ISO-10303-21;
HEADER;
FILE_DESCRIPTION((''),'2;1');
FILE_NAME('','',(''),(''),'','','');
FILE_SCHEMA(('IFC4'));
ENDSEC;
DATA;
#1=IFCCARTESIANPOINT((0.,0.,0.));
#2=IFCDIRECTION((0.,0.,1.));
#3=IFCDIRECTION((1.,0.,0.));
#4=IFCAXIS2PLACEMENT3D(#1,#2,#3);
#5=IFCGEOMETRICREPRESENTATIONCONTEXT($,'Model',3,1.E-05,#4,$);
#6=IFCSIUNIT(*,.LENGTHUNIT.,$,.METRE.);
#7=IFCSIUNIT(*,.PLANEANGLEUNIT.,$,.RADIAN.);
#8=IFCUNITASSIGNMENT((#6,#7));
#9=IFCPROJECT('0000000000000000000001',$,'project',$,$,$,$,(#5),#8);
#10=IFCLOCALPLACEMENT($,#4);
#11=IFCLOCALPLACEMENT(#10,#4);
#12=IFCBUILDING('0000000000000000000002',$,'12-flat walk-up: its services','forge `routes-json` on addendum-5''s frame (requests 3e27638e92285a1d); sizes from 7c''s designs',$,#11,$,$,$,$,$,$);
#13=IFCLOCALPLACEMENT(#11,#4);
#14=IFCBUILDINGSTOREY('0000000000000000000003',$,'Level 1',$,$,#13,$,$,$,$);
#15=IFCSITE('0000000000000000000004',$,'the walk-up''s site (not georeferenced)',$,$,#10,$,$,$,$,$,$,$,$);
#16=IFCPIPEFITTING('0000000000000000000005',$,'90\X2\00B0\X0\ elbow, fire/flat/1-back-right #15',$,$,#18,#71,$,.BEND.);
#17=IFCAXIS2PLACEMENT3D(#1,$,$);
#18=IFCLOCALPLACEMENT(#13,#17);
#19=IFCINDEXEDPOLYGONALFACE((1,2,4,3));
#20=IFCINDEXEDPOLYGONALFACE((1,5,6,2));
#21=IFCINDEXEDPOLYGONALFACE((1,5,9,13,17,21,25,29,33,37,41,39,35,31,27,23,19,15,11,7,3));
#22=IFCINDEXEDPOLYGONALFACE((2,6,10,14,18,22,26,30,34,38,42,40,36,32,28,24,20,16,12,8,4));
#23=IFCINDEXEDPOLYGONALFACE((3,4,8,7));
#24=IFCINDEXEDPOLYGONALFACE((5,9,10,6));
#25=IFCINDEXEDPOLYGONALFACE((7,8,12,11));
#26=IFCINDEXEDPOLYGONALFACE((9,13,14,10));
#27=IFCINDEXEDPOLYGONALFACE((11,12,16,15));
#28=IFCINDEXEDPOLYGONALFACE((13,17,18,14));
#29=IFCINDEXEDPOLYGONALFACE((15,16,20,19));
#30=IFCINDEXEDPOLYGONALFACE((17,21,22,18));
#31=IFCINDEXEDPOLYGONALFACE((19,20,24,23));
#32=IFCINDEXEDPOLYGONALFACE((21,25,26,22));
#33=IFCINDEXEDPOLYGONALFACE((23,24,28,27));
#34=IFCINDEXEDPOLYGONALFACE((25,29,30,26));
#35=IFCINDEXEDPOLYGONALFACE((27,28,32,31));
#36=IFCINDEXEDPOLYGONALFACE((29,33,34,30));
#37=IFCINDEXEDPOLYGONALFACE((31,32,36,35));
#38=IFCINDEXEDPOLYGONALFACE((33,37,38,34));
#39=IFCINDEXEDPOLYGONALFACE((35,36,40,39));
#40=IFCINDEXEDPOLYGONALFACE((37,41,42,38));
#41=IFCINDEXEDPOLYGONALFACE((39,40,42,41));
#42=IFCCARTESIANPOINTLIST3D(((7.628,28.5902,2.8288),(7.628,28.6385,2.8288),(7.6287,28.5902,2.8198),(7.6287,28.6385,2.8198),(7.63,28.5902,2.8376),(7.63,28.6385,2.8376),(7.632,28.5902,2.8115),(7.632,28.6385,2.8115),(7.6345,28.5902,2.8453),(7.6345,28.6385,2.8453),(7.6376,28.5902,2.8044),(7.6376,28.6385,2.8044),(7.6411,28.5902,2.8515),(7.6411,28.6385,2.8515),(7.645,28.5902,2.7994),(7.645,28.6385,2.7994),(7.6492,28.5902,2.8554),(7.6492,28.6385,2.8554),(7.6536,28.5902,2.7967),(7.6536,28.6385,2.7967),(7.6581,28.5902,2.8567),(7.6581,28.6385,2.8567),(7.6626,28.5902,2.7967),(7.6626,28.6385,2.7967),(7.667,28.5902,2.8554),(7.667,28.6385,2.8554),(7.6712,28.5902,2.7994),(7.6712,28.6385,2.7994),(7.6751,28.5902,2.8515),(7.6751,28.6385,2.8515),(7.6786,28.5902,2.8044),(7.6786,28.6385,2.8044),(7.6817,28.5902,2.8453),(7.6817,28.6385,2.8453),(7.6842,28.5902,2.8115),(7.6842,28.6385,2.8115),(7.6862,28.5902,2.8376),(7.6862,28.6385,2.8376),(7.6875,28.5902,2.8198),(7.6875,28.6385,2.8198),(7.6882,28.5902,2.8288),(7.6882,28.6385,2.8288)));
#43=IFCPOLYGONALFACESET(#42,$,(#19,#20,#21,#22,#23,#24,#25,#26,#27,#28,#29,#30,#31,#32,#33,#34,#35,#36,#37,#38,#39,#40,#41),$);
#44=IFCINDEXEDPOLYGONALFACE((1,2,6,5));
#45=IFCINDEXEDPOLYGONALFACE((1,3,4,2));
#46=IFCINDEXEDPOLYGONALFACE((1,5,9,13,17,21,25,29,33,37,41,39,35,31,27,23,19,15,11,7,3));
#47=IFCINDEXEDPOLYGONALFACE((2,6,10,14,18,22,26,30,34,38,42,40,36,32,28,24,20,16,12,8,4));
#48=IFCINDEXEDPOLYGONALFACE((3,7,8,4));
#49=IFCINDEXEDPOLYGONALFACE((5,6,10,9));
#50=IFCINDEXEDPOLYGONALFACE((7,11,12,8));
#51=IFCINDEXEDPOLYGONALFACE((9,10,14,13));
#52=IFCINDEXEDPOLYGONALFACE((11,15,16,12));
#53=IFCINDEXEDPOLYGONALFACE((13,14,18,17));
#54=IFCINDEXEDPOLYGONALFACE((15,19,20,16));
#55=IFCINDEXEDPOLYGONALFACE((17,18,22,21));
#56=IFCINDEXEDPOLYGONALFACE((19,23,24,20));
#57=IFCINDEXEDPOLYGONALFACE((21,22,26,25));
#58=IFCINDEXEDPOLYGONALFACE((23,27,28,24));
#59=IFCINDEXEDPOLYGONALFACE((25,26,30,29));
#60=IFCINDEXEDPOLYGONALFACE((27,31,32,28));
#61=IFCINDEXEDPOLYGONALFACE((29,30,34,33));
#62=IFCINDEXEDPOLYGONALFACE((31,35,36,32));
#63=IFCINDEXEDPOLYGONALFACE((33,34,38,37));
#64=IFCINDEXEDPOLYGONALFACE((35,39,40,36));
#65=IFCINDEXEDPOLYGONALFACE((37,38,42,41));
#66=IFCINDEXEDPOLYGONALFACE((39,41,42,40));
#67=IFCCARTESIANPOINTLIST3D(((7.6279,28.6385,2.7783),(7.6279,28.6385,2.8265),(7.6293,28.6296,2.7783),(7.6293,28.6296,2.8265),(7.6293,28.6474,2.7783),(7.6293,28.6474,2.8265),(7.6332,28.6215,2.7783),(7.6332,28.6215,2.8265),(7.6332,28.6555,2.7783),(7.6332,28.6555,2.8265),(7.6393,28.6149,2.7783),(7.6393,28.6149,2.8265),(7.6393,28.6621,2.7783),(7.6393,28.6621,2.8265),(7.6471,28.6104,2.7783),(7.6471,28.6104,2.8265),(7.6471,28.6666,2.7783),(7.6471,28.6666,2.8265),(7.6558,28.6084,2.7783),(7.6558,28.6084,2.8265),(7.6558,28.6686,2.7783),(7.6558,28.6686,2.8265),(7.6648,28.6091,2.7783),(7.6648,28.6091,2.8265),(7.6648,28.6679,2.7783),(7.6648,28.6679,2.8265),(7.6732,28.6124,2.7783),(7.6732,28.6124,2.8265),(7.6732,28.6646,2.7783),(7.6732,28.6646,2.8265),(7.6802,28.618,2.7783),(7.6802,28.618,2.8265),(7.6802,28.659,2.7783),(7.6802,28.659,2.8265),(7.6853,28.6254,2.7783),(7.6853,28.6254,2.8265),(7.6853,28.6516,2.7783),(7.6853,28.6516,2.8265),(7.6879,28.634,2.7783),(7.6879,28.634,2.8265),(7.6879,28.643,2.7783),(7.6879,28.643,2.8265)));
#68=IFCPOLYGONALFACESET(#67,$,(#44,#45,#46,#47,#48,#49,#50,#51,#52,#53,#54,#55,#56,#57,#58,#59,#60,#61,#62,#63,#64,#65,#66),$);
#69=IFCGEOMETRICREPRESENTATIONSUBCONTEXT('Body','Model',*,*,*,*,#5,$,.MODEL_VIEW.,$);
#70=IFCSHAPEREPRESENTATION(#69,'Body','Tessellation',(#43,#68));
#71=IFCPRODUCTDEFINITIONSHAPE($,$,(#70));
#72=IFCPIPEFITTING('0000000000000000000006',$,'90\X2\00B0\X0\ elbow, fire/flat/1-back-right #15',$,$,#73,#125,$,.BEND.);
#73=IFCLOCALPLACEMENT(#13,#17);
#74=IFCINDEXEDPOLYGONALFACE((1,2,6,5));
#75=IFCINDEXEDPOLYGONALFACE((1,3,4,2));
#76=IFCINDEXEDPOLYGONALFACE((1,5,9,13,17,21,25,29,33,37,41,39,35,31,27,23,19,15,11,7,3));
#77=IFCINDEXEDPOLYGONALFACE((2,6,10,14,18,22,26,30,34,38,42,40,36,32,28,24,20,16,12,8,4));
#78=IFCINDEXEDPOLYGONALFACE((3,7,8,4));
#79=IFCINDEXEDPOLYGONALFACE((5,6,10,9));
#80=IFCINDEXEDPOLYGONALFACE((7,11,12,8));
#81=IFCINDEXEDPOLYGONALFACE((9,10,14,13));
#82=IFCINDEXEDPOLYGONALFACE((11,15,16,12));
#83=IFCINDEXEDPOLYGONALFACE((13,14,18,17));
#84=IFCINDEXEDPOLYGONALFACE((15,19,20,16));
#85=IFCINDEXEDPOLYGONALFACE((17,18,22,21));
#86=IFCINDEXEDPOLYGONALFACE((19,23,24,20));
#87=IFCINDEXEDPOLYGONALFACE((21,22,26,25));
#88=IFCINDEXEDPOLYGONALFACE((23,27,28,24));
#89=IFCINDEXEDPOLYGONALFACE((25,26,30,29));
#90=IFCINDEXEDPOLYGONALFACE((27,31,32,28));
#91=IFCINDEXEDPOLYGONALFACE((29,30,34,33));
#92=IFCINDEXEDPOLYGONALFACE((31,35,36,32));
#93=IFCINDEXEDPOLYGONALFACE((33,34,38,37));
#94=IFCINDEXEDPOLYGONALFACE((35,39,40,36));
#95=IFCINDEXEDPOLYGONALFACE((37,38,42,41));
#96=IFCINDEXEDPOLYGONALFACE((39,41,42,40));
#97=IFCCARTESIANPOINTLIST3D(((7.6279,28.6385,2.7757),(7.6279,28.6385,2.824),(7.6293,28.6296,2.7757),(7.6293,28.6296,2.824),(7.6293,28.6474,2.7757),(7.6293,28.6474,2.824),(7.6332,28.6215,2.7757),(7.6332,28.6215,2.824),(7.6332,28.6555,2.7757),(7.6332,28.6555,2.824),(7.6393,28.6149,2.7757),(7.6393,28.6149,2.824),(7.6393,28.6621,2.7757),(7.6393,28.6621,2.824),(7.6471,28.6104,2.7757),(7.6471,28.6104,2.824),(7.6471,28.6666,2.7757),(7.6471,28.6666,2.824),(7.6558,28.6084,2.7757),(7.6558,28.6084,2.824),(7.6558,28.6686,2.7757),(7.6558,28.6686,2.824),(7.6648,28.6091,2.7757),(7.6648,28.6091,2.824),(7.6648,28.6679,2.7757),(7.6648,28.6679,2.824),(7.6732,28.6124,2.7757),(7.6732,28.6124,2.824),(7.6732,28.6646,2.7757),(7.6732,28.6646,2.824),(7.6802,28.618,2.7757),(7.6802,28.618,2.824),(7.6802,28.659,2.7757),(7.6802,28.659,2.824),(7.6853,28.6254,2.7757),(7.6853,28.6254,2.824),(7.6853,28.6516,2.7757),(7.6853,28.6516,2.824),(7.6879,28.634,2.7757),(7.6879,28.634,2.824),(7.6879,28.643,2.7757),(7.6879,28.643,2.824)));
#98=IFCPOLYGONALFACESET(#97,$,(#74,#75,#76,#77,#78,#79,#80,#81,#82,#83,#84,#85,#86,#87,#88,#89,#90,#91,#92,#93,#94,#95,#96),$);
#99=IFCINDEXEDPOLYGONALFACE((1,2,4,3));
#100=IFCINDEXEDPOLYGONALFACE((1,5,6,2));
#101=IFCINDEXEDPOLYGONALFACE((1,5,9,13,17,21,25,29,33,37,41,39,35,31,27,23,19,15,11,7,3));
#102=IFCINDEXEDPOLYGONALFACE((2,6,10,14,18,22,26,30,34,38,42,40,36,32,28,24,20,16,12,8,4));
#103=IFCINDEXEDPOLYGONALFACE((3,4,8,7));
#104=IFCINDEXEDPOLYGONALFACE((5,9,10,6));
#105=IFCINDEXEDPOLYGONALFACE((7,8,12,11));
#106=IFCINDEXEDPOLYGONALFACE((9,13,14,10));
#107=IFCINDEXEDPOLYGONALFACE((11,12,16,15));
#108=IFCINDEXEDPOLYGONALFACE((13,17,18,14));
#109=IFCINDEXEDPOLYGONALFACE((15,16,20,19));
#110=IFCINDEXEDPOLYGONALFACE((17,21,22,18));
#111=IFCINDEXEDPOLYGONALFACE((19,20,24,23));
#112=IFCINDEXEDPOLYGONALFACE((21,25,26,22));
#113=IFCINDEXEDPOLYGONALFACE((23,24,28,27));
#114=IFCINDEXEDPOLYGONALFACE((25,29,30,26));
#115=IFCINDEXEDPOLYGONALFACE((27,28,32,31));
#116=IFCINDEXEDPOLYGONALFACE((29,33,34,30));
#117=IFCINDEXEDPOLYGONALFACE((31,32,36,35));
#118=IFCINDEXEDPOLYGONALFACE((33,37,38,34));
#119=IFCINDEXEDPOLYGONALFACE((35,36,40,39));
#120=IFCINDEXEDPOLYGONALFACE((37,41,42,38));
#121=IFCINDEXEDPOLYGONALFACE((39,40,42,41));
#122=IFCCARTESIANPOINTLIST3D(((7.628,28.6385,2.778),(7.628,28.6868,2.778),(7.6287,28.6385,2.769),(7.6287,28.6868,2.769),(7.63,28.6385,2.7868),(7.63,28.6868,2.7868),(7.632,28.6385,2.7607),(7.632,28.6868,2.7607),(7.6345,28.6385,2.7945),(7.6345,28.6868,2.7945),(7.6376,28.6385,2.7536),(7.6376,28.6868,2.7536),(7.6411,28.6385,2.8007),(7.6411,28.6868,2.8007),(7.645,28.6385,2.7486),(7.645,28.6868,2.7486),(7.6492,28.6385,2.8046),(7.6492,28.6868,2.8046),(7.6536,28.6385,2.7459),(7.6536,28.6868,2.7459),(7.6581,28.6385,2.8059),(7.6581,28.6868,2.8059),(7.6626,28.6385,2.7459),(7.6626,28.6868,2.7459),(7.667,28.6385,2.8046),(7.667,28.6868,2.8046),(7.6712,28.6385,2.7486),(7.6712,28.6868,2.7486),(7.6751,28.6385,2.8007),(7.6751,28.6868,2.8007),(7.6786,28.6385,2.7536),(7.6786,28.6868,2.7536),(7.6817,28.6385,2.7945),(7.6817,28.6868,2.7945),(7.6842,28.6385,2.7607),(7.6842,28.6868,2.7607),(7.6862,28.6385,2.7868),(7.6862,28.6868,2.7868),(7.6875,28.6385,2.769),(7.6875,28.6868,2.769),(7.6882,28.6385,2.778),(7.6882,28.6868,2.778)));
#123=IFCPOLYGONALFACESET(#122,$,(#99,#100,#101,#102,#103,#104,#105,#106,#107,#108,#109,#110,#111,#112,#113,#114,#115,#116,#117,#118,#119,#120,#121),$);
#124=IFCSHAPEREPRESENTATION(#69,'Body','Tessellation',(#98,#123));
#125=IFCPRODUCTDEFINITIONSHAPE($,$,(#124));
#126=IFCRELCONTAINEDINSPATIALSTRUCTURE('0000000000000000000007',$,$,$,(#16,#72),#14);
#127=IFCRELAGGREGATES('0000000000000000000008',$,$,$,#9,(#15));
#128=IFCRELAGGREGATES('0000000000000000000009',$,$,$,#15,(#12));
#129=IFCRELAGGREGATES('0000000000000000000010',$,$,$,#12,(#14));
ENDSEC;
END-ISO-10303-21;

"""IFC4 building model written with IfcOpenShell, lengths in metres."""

from ifc_helpers import new_model, entity, si_unit, frame, origin_with_axes, place, context, subcontext, project, spatial, element, save


model = new_model("IFC4")

# Units and contexts
model_context = context("Model", 3, precision=1e-05, world=origin_with_axes())
body_context = subcontext(model_context, "Body", "Model", "MODEL_VIEW")
ifc_project = project(units=[si_unit("LENGTHUNIT", "METRE"), si_unit("PLANEANGLEUNIT", "RADIAN")], contexts=[model_context])

# Site, building, storey
site_placement = place(None, origin_with_axes())
site = spatial("IfcSite", under=ifc_project, at=site_placement, Name="the walk-up's site (not georeferenced)")
building_placement = place(site_placement, origin_with_axes())
building = spatial("IfcBuilding", under=site, at=building_placement, Name="12-flat walk-up: its services", Description="forge `routes-json` on addendum-5's frame (requests 3e27638e92285a1d); sizes from 7c's designs")
storey_placement = place(building_placement, origin_with_axes())
storey = spatial("IfcBuildingStorey", under=building, at=storey_placement, Name="Level 1")

# Pipe fittings
pipe_fitting_1_placement = place(storey_placement, frame((7.6581, 28.5902, 2.8265), z_axis=(0.0, 0.0, 1.0), x_axis=(1.0, 0.0, 0.0)))
element("IfcPipeFitting", 1, at=pipe_fitting_1_placement, inside=storey, Name="90° elbow, fire/flat/1-back-right #15", PredefinedType="BEND", context=body_context, shape_type="AdvancedSweptSolid", body=[
    entity("IfcSweptDiskSolid", entity("IfcPolyline", [entity("IfcCartesianPoint", [0.0, 0.0, 0.0]), entity("IfcCartesianPoint", [0.0, 0.0483, 0.0])]), 0.0302),
    entity("IfcSweptDiskSolid", entity("IfcPolyline", [entity("IfcCartesianPoint", [0.0, 0.0483, 0.0]), entity("IfcCartesianPoint", [0.0, 0.0483, -0.0483])]), 0.0302),
])
pipe_fitting_2_placement = place(storey_placement, frame((7.6581, 28.6385, 2.824), z_axis=(0.0, 0.0, 1.0), x_axis=(1.0, 0.0, 0.0)))
element("IfcPipeFitting", 2, at=pipe_fitting_2_placement, inside=storey, Name="90° elbow, fire/flat/1-back-right #15", PredefinedType="BEND", context=body_context, shape_type="AdvancedSweptSolid", body=[
    entity("IfcSweptDiskSolid", entity("IfcPolyline", [entity("IfcCartesianPoint", [0.0, 0.0, 0.0]), entity("IfcCartesianPoint", [0.0, 0.0, -0.0483])]), 0.0302),
    entity("IfcSweptDiskSolid", entity("IfcPolyline", [entity("IfcCartesianPoint", [0.0, 0.0, -0.0483]), entity("IfcCartesianPoint", [0.0, 0.0483, -0.0483])]), 0.0302),
])

save(model, "model.ifc")
